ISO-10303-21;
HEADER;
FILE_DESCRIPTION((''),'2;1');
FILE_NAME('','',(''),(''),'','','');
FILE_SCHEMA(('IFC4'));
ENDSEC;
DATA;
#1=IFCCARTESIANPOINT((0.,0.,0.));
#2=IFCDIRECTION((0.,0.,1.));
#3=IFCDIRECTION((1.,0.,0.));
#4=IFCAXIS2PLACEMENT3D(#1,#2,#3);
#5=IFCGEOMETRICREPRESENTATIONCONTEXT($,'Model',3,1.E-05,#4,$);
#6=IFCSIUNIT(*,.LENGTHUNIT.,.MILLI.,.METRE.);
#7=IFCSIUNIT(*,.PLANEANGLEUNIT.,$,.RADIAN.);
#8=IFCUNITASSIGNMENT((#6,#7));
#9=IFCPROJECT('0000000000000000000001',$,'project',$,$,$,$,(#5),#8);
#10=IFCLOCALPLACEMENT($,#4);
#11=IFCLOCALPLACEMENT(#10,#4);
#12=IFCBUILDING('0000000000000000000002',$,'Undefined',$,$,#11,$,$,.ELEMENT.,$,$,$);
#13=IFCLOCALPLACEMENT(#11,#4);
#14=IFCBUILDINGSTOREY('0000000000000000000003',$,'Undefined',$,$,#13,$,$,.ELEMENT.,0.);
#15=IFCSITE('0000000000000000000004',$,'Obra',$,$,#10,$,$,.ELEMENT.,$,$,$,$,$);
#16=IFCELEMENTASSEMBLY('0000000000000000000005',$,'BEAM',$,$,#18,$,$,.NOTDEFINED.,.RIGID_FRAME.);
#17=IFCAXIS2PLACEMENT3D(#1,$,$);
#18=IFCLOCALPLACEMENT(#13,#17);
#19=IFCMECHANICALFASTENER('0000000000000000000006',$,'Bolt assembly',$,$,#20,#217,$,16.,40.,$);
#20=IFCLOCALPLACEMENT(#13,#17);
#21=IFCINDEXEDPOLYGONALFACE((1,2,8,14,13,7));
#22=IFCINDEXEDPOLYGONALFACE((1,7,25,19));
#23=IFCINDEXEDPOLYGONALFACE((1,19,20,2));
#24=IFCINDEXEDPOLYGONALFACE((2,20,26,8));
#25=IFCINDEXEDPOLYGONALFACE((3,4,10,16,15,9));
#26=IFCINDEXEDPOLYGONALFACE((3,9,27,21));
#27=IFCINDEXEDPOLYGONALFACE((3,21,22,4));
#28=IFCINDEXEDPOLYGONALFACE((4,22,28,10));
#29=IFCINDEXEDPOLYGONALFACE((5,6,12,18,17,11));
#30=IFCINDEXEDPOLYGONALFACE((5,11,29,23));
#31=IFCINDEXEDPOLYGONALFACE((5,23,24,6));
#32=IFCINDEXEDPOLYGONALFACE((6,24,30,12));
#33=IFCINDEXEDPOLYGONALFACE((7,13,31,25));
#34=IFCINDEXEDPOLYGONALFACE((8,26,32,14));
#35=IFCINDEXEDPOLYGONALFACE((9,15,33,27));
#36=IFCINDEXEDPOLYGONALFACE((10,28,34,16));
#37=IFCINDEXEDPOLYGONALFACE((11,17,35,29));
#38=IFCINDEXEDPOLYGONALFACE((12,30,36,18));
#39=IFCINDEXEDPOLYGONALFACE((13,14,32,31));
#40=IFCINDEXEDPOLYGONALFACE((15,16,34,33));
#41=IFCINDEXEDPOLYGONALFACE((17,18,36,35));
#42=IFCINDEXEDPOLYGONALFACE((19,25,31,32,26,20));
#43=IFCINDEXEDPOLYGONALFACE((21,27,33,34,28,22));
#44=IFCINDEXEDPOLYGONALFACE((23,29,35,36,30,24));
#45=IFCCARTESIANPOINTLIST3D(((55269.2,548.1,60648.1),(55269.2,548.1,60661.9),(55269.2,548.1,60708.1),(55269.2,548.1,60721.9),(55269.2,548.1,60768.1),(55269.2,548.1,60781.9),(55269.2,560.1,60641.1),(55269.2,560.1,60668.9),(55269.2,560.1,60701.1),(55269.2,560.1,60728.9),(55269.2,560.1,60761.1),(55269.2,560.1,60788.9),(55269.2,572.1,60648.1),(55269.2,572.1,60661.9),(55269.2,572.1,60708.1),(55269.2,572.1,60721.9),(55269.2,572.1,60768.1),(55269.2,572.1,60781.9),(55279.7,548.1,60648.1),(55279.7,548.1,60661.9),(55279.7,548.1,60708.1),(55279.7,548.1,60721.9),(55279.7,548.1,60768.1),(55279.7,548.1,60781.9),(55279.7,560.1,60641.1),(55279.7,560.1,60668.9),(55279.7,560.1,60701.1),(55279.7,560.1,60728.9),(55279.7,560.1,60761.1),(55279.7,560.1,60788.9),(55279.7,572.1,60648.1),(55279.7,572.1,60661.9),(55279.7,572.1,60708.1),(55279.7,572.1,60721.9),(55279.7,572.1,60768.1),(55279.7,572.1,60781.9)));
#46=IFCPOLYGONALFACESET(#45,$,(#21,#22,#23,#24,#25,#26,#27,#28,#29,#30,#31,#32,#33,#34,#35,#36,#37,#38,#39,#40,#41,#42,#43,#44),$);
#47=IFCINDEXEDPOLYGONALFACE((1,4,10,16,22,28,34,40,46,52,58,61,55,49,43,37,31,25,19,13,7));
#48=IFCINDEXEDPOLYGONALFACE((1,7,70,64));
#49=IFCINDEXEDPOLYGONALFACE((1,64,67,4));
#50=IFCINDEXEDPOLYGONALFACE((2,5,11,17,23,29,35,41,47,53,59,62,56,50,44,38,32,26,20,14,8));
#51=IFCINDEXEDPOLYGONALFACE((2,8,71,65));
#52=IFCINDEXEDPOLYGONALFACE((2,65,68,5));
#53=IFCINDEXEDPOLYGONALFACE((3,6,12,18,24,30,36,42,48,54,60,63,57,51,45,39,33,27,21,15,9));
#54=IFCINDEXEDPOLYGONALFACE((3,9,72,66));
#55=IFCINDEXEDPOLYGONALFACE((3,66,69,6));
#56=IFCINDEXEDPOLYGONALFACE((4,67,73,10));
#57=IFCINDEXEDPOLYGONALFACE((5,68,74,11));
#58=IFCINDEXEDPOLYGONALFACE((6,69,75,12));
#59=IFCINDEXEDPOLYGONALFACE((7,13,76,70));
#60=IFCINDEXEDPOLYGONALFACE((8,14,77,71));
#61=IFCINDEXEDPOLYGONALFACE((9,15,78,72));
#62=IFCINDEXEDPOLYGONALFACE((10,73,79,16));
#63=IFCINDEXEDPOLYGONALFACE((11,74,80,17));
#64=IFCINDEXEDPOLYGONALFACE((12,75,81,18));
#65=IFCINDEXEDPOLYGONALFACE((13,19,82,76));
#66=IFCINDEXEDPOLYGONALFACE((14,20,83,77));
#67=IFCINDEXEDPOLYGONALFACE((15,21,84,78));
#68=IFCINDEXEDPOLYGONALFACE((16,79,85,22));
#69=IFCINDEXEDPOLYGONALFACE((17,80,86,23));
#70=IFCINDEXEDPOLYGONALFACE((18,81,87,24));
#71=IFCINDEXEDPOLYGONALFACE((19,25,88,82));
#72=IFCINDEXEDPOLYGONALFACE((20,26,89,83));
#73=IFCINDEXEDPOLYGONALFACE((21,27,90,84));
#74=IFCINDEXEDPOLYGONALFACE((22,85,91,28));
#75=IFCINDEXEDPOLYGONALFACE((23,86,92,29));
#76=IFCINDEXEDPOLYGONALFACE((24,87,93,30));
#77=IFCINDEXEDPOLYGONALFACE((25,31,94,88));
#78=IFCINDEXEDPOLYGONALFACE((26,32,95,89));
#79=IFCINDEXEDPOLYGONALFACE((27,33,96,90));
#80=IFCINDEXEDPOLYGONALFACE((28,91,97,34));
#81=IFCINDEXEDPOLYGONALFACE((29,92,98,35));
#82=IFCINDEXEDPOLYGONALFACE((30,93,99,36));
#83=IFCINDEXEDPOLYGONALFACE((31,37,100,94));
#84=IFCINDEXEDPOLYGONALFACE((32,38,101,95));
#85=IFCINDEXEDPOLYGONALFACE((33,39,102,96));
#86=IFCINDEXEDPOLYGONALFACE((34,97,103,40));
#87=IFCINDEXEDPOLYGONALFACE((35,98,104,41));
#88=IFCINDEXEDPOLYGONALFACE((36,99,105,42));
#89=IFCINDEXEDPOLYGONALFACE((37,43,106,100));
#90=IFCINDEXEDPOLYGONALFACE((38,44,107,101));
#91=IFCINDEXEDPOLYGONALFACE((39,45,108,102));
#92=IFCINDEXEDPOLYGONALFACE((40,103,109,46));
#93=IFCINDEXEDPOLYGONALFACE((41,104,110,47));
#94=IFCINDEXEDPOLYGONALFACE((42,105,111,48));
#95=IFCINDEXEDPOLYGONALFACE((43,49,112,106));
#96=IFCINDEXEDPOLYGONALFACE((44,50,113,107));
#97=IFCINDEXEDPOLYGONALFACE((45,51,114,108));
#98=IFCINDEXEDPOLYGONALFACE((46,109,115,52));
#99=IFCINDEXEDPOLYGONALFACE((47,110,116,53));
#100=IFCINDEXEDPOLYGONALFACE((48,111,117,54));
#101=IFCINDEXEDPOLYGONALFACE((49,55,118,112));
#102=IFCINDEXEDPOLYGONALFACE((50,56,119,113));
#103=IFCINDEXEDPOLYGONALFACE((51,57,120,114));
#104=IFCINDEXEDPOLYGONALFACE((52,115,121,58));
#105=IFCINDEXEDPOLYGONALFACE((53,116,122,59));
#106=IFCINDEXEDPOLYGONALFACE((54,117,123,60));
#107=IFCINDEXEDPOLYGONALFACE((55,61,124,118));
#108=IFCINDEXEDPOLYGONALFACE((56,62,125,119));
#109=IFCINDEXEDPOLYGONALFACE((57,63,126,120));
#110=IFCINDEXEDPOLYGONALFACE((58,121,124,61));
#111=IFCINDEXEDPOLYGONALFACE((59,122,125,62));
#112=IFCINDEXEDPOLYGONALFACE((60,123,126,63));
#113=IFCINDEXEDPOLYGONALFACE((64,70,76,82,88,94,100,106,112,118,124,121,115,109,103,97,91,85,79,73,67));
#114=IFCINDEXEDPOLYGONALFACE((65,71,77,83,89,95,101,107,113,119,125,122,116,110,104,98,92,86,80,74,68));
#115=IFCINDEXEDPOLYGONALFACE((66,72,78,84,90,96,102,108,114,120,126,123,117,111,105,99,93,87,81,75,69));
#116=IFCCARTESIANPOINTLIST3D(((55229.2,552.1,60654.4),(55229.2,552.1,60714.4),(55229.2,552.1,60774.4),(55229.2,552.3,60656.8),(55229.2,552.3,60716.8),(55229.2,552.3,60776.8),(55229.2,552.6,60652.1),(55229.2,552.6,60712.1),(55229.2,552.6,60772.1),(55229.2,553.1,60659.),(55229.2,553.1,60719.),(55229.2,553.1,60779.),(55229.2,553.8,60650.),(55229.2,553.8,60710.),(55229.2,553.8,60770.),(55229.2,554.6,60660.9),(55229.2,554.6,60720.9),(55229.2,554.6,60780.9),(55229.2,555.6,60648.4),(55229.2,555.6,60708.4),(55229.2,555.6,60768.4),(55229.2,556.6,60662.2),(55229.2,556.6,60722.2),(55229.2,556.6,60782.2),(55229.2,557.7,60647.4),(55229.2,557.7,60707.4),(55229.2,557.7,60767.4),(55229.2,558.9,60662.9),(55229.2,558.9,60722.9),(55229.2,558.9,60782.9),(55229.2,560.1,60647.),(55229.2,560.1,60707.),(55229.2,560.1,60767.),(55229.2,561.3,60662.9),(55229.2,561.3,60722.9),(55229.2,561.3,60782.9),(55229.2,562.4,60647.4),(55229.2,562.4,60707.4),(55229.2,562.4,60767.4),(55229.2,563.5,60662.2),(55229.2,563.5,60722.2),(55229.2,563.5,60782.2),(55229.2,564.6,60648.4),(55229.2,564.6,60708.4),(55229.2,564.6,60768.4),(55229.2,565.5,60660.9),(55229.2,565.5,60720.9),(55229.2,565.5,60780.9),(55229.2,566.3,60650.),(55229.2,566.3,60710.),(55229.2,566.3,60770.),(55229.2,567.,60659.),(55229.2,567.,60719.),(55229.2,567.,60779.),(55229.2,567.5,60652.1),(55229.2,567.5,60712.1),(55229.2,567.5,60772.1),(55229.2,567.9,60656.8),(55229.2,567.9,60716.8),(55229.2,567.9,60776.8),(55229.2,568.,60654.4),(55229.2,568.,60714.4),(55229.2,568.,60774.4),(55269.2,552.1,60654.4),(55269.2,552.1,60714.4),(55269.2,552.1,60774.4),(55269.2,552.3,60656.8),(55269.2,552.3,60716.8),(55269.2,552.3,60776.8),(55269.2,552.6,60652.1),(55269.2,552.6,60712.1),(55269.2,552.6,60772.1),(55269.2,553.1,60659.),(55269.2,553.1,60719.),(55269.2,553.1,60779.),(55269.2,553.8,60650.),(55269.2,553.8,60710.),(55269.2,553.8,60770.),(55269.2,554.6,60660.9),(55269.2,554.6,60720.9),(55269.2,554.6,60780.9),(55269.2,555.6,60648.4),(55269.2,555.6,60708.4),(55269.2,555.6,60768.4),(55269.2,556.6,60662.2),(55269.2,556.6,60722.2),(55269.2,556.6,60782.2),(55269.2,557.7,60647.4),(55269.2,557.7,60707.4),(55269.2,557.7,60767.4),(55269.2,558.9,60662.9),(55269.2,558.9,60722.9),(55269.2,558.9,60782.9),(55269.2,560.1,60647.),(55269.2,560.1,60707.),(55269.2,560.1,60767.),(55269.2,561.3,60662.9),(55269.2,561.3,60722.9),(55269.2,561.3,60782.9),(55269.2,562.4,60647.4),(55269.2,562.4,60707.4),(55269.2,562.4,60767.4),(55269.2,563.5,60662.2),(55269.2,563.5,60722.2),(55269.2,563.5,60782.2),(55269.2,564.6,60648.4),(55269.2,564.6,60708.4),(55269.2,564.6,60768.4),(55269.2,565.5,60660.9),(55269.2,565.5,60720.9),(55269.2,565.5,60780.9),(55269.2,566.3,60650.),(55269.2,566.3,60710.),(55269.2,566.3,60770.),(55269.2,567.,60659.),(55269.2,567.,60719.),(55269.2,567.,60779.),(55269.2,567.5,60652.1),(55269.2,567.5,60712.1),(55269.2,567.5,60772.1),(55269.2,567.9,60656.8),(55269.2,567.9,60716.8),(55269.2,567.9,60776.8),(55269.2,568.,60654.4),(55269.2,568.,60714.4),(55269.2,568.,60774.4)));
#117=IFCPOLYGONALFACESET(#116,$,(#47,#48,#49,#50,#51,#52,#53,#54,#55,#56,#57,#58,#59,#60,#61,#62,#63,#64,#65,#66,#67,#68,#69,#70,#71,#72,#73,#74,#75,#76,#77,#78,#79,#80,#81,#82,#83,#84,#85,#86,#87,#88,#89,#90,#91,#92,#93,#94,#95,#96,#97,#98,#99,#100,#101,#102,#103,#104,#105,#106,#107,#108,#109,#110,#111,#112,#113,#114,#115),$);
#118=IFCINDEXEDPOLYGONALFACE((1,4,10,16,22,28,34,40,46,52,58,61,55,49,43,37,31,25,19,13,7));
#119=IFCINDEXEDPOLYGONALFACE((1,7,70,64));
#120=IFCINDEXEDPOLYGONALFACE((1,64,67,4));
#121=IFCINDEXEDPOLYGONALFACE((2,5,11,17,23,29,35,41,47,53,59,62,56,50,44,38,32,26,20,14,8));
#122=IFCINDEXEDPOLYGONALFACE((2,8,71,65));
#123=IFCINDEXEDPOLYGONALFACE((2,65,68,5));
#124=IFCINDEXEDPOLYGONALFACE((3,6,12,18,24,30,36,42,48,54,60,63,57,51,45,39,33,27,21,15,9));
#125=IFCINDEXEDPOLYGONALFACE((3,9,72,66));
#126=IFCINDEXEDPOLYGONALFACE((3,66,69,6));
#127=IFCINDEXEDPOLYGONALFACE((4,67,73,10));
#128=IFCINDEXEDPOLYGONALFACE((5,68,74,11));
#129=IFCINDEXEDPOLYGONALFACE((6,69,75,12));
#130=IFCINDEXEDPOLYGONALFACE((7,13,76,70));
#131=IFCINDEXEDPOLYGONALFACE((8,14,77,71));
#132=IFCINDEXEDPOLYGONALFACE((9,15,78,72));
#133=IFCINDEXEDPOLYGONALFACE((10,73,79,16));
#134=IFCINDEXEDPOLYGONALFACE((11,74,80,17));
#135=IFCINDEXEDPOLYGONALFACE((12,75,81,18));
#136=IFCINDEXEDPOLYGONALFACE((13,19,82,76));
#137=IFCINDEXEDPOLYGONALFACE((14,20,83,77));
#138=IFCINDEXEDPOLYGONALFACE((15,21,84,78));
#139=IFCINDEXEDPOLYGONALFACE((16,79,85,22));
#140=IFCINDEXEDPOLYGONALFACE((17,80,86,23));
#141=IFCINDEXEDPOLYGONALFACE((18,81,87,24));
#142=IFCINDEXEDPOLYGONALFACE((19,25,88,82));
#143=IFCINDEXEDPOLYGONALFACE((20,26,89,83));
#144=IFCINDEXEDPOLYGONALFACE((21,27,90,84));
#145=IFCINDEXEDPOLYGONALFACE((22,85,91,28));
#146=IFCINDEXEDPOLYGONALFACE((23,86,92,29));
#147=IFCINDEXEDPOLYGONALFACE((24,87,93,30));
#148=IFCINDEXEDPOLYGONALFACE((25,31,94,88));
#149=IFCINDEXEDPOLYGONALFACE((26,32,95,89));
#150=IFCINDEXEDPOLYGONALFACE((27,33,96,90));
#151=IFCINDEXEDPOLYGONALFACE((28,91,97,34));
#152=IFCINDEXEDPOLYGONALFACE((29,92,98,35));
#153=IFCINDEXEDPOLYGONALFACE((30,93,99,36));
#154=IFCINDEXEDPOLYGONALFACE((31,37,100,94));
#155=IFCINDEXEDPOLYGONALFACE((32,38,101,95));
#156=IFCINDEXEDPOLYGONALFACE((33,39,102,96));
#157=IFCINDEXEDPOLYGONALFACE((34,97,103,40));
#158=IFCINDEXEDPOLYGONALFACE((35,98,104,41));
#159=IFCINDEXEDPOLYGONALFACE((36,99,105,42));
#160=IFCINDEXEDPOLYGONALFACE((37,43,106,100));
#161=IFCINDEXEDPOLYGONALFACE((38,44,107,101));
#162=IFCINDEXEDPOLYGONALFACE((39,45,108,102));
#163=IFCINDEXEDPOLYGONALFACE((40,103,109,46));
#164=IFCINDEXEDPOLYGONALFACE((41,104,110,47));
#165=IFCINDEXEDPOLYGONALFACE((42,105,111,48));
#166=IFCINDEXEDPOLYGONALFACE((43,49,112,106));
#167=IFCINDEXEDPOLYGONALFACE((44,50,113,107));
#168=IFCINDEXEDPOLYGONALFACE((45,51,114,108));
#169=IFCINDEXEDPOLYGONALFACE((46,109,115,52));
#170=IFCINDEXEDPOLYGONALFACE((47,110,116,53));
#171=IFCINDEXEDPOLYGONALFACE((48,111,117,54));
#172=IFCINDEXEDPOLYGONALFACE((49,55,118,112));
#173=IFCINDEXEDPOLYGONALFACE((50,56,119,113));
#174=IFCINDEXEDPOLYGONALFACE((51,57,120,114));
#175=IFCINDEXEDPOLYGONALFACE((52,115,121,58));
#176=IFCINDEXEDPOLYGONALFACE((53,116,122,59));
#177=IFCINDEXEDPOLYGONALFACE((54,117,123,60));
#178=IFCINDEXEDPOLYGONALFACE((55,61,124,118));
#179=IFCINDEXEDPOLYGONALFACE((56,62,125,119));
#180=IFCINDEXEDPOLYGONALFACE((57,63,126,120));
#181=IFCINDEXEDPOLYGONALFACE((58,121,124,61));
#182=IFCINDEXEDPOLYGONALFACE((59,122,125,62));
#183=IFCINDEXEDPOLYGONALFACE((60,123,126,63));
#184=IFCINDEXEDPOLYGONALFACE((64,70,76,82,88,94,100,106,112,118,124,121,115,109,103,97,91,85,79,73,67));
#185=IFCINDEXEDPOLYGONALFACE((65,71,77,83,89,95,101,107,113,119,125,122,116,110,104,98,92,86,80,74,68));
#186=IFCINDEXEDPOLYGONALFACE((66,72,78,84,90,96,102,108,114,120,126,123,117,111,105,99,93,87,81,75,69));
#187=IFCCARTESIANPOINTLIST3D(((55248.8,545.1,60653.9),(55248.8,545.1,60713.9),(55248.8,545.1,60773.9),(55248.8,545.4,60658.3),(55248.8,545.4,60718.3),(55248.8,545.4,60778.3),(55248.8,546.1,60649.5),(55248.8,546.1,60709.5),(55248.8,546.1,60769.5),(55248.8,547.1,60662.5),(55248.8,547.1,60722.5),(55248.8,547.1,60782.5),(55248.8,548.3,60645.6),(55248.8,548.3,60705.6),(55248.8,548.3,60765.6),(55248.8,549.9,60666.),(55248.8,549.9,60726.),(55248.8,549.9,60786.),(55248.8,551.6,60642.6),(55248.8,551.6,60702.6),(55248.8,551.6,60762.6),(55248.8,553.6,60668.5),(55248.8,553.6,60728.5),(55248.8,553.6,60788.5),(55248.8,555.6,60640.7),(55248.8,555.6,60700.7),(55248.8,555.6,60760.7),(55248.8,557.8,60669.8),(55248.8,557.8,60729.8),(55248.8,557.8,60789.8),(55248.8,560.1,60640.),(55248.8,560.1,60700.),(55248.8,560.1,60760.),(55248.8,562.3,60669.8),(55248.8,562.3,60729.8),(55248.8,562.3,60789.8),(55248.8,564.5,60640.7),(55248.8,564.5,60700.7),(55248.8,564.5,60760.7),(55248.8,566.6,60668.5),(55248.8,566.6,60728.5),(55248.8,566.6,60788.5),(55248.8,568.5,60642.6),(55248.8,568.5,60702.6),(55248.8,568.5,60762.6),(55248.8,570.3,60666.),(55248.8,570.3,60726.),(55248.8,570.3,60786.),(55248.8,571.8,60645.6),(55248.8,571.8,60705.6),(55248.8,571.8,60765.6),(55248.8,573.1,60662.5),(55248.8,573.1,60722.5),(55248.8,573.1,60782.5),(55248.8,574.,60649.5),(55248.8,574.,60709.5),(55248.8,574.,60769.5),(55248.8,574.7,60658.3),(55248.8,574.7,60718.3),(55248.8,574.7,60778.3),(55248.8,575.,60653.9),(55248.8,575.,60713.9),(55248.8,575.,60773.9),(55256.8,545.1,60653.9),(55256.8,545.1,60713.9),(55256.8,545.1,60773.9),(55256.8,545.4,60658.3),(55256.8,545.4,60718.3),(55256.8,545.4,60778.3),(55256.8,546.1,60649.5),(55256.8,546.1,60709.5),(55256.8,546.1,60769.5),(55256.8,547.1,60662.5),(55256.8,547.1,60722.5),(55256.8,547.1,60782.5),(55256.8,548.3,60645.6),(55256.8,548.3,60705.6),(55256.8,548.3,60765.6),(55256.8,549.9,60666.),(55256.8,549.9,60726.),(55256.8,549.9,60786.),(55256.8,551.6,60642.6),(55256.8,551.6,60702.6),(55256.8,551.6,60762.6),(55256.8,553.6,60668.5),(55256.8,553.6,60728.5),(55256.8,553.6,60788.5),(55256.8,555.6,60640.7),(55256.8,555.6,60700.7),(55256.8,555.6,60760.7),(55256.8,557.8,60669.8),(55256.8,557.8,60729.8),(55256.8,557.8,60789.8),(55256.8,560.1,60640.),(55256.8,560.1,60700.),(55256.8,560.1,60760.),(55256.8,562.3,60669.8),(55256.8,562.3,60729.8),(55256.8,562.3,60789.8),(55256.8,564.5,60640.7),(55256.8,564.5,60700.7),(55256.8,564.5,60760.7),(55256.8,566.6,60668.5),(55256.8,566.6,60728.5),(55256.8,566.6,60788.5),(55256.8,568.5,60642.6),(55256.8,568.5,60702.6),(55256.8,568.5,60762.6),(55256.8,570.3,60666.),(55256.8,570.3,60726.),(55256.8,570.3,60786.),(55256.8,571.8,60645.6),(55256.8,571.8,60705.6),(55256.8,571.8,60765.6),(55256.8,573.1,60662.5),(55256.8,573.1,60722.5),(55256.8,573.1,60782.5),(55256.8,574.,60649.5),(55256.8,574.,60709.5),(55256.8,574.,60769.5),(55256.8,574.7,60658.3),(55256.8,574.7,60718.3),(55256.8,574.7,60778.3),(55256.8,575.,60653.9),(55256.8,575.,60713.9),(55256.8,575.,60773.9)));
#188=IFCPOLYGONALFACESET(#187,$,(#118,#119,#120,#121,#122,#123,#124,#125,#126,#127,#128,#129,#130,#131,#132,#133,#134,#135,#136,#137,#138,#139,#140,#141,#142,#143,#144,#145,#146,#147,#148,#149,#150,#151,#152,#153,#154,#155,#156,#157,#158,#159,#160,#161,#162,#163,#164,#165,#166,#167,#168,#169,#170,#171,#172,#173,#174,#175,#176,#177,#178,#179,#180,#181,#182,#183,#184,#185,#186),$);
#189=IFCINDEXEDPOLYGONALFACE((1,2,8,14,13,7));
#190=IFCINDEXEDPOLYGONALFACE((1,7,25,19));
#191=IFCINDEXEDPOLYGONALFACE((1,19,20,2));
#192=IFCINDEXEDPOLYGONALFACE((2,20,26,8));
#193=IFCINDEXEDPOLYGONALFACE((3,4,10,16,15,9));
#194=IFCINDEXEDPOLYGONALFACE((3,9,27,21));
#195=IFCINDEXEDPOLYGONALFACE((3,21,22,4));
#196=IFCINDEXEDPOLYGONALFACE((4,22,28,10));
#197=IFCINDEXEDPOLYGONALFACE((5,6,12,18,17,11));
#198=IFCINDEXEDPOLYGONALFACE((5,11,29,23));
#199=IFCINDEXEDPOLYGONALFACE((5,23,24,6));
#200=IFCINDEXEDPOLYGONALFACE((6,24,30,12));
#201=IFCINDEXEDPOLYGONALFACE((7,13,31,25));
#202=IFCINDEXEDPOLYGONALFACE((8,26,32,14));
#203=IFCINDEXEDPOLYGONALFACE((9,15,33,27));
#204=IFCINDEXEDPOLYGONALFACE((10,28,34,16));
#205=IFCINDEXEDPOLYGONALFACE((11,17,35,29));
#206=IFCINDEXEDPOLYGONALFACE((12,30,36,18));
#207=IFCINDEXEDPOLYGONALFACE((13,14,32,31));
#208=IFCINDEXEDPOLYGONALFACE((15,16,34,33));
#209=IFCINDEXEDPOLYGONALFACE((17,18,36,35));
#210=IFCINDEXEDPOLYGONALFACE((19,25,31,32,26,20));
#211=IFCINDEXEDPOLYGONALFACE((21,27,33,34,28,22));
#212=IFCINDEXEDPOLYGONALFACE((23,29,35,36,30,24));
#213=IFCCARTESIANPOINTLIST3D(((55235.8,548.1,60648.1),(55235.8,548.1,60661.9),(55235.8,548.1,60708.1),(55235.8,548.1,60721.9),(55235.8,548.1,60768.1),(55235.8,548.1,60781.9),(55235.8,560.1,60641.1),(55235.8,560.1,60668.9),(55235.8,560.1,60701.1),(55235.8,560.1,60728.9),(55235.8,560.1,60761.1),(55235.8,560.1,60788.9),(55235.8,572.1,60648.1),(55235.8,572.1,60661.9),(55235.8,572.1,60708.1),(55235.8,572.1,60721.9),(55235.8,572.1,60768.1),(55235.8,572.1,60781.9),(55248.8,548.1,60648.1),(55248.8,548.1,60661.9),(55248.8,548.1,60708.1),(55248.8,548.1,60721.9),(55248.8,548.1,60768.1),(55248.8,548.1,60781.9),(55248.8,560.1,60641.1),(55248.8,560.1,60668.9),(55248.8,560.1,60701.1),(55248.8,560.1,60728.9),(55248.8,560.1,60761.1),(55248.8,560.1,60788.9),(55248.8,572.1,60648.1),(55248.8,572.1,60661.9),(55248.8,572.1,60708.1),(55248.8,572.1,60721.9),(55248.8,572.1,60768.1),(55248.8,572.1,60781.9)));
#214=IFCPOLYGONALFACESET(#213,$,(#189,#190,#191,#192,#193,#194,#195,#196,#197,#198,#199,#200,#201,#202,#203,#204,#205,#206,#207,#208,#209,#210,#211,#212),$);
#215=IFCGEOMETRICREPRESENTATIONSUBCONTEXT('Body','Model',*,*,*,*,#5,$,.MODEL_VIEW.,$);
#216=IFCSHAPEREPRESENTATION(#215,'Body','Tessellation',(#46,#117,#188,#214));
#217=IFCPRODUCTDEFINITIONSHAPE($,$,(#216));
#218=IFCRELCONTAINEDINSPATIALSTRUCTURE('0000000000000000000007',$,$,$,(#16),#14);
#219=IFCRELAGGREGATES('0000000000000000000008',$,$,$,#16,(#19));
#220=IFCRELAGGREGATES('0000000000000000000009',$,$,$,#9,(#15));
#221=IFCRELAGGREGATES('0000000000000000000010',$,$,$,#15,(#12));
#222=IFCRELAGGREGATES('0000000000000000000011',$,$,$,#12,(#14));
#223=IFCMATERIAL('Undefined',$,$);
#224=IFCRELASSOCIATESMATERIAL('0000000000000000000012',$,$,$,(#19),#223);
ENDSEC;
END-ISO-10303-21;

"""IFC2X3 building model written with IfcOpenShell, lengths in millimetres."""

from ifc_helpers import new_model, si_unit, frame, origin_with_axes, origin_2d_with_axis, place, context, subcontext, project, spatial, polyline, circle, outline, extrude, source, transform, mapped, material, element, aggregate, save


model = new_model("IFC2X3")

# Units and contexts
model_context = context("Model", 3, precision=1e-05, world=origin_with_axes())
body_context = subcontext(model_context, "Body", "Model", "MODEL_VIEW")
ifc_project = project(units=[si_unit("LENGTHUNIT", "METRE", prefix="MILLI"), si_unit("PLANEANGLEUNIT", "RADIAN")], contexts=[model_context])

# Site, building, storey
site_placement = place(None, origin_with_axes())
site = spatial("IfcSite", under=ifc_project, at=site_placement, Name="Obra", CompositionType="ELEMENT")
building_placement = place(site_placement, origin_with_axes())
building = spatial("IfcBuilding", under=site, at=building_placement, Name="Undefined", CompositionType="ELEMENT")
storey_placement = place(building_placement, origin_with_axes())
storey = spatial("IfcBuildingStorey", under=building, at=storey_placement, Name="Undefined", CompositionType="ELEMENT", Elevation=0.0)

# Element assembly
ifc_material_1 = material(Name="Undefined")
assembly_1_placement = place(storey_placement, origin_with_axes())
assembly_1 = element("IfcElementAssembly", 1, at=assembly_1_placement, inside=storey, Name="BEAM", AssemblyPlace="NOTDEFINED", PredefinedType="RIGID_FRAME")

# Mechanical fastener
shared_shape_1 = source(origin_with_axes(), body_context, "Body", "SweptSolid", [
    extrude(outline(polyline([(13.9, 0.0), (6.9, 12.0), (-6.9, 12.0), (-13.9, 0.0), (-6.9, -12.0), (6.9, -12.0), (13.9, 0.0)])), frame((0.0, -19.7, 0.0), z_axis=(0.0, 1.0, 0.0), x_axis=(1.0, 0.0, 0.0)), (0.0, 0.0, 1.0), 10.6),
    extrude(circle(Radius=8.0, at=origin_2d_with_axis()), frame((0.0, -9.1, 0.0), z_axis=(0.0, 1.0, 0.0), x_axis=(1.0, 0.0, 0.0)), (0.0, 0.0, 1.0), 40.0),
    extrude(circle(Radius=15.0, at=origin_2d_with_axis()), frame((0.0, 3.3, 0.0), z_axis=(0.0, 1.0, 0.0), x_axis=(1.0, 0.0, 0.0)), (0.0, 0.0, 1.0), 8.0),
    extrude(outline(polyline([(13.9, 0.0), (6.9, 12.0), (-6.9, 12.0), (-13.9, 0.0), (-6.9, -12.0), (6.9, -12.0), (13.9, 0.0)])), frame((0.0, 11.3, 0.0), z_axis=(0.0, 1.0, 0.0), x_axis=(1.0, 0.0, 0.0)), (0.0, 0.0, 1.0), 13.0),
])
mechanical_fastener_1_placement = place(assembly_1_placement, frame((55260.1, 510.1, 60835.0), z_axis=(-0.000002, 1.0, 0.0), x_axis=(0.0, 0.0, -1.0)))
mechanical_fastener_1 = element("IfcMechanicalFastener", 2, at=mechanical_fastener_1_placement, material=ifc_material_1, Name="Bolt assembly", NominalDiameter=16.0, NominalLength=40.0, context=body_context, shape_type="MappedRepresentation", body=[
    mapped(shared_shape_1, transform((60.0, 0.0, 50.0))),
    mapped(shared_shape_1, transform((120.0, 0.0, 50.0))),
    mapped(shared_shape_1, transform((180.0, 0.0, 50.0))),
])
aggregate(assembly_1, [mechanical_fastener_1])

save(model, "model.ifc")
